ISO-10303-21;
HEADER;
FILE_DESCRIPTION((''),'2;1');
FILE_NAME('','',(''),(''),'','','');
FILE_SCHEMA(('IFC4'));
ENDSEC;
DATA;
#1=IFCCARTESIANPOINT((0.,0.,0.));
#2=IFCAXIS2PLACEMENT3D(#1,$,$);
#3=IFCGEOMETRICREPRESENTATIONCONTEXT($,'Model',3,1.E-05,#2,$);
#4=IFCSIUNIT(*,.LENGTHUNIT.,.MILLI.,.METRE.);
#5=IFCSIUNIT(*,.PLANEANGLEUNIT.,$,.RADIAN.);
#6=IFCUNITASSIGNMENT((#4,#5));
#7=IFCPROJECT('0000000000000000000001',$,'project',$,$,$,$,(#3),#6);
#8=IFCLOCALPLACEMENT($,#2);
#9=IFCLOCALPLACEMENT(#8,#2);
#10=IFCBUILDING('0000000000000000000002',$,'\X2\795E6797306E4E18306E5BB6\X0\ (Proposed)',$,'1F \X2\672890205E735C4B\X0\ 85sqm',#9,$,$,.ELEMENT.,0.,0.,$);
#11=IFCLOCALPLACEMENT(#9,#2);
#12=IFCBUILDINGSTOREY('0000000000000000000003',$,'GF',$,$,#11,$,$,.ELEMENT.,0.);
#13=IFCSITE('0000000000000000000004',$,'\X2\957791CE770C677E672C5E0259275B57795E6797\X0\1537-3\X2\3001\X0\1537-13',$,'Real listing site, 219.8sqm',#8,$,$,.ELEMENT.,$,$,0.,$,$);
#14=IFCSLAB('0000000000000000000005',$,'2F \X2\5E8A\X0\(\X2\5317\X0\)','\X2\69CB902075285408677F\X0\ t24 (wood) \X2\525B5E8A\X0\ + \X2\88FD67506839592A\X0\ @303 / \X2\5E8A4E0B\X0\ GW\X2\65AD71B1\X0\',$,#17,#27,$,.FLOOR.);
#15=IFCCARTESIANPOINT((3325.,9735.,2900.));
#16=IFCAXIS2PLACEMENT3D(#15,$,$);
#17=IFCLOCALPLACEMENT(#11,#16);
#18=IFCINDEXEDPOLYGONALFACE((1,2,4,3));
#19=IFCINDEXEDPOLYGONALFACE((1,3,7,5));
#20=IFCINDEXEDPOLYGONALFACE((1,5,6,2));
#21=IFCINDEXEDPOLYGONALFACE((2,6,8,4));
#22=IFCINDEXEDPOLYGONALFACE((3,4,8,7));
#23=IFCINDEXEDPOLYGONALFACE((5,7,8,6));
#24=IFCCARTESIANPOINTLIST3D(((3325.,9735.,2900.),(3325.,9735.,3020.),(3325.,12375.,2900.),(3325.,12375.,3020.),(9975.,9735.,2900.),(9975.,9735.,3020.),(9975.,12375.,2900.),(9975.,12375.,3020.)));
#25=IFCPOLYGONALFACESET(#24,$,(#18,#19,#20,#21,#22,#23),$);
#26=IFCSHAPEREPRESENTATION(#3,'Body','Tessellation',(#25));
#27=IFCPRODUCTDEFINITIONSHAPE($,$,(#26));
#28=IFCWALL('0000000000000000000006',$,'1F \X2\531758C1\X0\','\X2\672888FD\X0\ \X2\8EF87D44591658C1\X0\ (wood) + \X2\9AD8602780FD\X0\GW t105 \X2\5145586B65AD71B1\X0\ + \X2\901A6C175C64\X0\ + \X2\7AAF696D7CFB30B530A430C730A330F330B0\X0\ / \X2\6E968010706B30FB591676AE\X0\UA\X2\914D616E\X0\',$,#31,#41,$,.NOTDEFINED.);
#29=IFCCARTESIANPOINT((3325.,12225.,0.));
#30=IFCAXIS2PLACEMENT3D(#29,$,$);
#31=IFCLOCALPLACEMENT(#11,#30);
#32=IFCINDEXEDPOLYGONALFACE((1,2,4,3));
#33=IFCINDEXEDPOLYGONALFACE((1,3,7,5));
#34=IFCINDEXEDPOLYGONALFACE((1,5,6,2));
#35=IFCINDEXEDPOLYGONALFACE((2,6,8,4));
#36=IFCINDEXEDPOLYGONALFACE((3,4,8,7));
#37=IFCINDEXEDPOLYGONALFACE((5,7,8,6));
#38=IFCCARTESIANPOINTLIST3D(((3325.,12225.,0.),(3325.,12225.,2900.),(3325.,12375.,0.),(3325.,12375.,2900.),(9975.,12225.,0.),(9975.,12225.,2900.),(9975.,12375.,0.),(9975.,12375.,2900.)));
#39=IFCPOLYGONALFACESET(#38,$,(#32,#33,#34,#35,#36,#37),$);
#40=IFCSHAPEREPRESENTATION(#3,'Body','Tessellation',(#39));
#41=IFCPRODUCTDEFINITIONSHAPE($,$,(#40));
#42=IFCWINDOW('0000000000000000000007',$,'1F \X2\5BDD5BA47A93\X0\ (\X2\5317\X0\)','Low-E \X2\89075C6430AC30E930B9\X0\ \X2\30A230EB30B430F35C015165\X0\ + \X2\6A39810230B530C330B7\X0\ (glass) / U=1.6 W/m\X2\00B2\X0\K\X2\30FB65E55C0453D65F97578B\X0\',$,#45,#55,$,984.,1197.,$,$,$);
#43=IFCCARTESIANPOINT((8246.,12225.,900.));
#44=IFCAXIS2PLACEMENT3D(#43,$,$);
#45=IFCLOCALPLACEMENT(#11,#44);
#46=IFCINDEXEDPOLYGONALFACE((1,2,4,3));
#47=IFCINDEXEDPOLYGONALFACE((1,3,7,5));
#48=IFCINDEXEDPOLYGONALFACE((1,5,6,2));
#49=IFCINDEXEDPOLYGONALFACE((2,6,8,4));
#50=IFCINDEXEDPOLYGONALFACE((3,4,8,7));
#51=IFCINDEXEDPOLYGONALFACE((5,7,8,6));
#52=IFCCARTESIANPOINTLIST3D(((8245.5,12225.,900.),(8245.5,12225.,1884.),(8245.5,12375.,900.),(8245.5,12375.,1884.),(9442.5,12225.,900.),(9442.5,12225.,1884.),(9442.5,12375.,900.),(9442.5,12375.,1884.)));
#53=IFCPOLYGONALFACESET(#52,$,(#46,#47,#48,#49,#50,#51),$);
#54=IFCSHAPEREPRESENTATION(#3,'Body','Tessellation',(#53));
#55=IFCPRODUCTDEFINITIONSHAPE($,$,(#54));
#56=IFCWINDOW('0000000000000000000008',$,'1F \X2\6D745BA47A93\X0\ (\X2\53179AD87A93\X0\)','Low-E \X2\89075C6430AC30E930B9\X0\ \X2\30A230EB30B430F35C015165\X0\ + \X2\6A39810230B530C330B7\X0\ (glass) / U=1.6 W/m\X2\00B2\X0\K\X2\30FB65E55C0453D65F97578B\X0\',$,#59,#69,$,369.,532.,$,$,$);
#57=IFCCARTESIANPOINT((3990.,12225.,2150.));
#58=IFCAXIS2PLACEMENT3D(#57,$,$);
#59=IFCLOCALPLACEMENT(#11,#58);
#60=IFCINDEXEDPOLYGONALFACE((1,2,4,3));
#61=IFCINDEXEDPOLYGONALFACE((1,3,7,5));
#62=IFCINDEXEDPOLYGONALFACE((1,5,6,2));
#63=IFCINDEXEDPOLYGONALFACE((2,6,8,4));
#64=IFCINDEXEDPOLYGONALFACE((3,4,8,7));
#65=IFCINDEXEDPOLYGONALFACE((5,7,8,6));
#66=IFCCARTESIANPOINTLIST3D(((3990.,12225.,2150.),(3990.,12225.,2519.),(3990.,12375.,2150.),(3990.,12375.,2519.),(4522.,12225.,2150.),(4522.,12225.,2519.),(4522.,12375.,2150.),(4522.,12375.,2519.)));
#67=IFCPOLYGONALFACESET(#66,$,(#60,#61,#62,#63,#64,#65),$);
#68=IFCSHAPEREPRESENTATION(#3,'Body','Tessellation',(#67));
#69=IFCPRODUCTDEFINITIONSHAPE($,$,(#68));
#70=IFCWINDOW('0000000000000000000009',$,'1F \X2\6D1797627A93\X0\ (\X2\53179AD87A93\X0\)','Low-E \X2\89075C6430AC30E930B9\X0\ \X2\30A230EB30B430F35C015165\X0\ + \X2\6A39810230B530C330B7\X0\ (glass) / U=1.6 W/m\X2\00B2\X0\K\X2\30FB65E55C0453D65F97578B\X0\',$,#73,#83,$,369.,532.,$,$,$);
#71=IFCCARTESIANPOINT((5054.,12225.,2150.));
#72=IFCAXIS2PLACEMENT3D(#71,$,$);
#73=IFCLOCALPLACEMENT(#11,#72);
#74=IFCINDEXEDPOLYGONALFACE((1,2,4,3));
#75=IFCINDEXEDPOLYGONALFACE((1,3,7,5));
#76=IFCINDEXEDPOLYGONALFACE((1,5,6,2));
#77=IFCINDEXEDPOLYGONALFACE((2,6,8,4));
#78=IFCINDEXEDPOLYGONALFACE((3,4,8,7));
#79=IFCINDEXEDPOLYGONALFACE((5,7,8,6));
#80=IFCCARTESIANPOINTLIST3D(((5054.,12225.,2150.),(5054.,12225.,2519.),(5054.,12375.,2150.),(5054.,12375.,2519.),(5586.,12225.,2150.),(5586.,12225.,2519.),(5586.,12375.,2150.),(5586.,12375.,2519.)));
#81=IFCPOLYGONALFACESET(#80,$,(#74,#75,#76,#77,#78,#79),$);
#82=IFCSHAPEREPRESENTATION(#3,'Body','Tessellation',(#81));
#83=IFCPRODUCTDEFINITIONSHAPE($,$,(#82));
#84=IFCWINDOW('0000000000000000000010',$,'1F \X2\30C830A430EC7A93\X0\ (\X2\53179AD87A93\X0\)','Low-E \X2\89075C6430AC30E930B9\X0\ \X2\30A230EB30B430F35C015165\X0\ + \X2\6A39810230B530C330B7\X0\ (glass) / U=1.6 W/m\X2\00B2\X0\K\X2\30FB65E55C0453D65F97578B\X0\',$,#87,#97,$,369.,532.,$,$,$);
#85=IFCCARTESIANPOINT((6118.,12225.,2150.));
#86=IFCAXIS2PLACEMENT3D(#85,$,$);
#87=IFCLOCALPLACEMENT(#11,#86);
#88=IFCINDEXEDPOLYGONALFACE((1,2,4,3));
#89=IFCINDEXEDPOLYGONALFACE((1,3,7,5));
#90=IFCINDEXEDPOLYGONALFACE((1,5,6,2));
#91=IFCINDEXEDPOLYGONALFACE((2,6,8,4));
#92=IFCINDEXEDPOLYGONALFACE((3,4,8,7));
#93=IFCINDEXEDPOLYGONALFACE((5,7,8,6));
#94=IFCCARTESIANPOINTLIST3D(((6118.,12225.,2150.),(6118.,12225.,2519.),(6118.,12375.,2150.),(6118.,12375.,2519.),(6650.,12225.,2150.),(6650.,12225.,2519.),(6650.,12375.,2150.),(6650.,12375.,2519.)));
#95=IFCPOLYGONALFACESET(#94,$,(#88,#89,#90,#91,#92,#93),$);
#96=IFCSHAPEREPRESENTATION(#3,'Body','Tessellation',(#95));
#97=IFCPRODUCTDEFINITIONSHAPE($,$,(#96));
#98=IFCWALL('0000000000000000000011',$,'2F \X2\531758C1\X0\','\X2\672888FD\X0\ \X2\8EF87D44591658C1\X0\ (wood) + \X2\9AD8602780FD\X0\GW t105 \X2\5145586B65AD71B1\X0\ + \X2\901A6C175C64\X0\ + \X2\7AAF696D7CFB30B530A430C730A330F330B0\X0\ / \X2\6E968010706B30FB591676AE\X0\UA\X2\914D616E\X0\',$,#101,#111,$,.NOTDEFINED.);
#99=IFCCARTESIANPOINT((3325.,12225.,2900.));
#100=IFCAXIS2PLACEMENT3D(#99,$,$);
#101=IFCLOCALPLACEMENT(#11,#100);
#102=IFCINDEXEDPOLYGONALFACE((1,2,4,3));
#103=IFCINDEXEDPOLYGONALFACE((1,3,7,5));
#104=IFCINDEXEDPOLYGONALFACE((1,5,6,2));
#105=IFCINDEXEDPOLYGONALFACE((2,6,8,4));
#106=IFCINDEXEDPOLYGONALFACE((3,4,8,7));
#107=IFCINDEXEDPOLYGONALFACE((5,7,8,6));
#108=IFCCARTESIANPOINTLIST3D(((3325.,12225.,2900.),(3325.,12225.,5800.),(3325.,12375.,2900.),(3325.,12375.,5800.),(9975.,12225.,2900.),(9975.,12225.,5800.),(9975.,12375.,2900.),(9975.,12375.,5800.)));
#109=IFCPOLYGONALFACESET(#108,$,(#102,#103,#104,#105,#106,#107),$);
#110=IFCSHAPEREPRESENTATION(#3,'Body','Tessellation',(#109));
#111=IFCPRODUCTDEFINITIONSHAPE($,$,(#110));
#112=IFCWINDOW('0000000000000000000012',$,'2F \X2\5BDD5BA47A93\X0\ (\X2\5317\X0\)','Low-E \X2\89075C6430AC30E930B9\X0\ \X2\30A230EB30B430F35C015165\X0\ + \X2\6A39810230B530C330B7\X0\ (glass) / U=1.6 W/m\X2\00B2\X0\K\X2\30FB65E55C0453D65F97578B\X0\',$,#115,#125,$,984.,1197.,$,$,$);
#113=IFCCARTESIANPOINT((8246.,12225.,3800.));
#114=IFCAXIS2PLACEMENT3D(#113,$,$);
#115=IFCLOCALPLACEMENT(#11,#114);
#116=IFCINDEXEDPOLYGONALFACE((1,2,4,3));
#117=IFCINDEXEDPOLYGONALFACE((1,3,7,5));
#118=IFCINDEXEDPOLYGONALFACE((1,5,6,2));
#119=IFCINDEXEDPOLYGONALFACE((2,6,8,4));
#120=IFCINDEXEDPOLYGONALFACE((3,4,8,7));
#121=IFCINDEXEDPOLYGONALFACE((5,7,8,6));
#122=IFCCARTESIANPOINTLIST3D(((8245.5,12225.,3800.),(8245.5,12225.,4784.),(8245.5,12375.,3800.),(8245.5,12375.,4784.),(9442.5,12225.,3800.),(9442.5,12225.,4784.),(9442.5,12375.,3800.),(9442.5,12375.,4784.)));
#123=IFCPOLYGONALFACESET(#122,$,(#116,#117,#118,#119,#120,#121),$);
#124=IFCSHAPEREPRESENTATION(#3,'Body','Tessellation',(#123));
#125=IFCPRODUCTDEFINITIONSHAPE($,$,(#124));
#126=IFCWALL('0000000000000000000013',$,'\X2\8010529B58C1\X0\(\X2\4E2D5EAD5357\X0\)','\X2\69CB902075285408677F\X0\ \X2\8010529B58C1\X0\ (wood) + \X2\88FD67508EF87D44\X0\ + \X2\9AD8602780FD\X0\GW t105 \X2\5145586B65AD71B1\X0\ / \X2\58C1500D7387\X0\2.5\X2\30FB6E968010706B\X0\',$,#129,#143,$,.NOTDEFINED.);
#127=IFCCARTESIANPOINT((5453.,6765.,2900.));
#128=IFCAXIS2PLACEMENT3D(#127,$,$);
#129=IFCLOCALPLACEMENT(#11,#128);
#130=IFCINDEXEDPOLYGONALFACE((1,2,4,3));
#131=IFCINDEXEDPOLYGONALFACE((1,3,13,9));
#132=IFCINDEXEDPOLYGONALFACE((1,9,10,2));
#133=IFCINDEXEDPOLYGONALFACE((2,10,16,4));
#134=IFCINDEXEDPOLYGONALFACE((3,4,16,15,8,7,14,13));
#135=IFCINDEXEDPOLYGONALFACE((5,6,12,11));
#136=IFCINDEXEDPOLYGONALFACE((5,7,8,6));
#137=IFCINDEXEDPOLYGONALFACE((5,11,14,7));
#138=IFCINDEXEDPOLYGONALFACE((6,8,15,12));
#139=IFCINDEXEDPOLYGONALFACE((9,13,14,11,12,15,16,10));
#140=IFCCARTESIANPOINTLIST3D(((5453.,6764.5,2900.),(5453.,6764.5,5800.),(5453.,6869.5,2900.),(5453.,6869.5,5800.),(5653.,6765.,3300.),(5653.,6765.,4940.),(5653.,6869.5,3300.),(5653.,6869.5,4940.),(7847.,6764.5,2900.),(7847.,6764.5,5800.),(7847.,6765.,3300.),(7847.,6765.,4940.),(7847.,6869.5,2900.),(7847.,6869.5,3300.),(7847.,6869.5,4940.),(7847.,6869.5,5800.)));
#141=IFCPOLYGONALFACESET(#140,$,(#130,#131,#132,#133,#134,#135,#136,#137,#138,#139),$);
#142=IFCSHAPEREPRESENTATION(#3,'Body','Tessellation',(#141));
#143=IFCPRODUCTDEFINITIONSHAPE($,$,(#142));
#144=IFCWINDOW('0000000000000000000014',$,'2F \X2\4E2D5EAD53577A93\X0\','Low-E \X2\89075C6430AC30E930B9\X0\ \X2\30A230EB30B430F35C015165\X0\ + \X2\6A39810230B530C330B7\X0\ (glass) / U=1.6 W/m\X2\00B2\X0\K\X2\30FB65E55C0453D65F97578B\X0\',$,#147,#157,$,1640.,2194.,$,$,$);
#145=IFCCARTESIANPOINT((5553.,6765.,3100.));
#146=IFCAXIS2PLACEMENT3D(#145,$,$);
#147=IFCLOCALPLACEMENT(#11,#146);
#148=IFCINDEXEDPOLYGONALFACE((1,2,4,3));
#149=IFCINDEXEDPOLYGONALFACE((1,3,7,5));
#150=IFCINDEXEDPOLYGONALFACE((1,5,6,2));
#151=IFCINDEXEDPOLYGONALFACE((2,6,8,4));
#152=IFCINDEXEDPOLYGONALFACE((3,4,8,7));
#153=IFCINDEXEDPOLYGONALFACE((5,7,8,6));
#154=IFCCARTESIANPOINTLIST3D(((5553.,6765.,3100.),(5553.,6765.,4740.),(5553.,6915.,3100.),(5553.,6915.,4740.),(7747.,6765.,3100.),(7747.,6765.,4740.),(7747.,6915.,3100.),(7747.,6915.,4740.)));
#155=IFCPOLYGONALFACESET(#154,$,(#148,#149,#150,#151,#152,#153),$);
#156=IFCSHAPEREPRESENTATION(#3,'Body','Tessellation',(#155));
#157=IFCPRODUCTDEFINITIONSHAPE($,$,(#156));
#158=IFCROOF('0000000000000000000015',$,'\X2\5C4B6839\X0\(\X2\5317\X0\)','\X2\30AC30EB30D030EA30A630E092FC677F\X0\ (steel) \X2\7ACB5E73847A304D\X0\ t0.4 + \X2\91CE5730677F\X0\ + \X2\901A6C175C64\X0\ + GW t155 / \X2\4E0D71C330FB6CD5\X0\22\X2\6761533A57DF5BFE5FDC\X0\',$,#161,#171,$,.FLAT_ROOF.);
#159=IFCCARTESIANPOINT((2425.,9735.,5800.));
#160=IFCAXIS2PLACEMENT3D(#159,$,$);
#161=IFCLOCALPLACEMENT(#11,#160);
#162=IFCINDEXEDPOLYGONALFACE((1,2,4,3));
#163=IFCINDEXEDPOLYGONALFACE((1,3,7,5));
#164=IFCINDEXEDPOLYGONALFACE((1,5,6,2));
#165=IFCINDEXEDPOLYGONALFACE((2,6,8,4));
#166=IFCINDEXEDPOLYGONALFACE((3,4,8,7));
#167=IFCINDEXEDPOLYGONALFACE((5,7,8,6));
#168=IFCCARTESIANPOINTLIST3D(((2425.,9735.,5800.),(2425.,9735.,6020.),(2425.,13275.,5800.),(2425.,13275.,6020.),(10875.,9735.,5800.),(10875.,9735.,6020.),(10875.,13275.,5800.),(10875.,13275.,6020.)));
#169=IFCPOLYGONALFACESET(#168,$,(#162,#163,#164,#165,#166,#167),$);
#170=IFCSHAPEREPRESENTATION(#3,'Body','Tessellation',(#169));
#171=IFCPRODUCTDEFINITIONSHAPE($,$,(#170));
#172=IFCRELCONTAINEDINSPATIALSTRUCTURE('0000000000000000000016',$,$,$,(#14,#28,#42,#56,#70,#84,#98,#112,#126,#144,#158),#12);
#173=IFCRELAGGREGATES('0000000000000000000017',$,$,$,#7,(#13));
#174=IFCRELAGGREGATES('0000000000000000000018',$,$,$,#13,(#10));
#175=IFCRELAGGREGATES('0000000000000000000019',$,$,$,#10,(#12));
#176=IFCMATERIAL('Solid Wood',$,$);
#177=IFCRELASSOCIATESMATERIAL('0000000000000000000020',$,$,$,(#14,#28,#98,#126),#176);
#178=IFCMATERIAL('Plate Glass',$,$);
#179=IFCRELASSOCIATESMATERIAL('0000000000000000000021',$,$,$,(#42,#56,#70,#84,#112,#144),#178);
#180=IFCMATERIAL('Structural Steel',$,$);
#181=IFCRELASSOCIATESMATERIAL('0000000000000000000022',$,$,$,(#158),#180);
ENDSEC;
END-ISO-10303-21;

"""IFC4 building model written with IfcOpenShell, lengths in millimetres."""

from ifc_helpers import new_model, si_unit, frame, frame_2d, origin, place, context, project, spatial, rectangle, extrude, material, element, fill, save


model = new_model("IFC4")

# Units and contexts
model_context = context("Model", 3, precision=1e-05, world=origin())
ifc_project = project(units=[si_unit("LENGTHUNIT", "METRE", prefix="MILLI"), si_unit("PLANEANGLEUNIT", "RADIAN")], contexts=[model_context])

# Site, building, storey
site_placement = place(None, origin())
site = spatial("IfcSite", under=ifc_project, at=site_placement, Name="長野県松本市大字神林1537-3、1537-13", ObjectType="Real listing site, 219.8sqm", CompositionType="ELEMENT", RefElevation=0.0)
building_placement = place(site_placement, origin())
building = spatial("IfcBuilding", under=site, at=building_placement, Name="神林の丘の家 (Proposed)", ObjectType="1F 木造平屋 85sqm", CompositionType="ELEMENT", ElevationOfRefHeight=0.0, ElevationOfTerrain=0.0)
storey_placement = place(building_placement, origin())
storey = spatial("IfcBuildingStorey", under=building, at=storey_placement, Name="GF", CompositionType="ELEMENT", Elevation=0.0)

# Slab
ifc_material_1 = material(Name="Solid Wood")
slab_1_placement = place(storey_placement, frame((3325.0, 9735.0, 2900.0)))
element("IfcSlab", 1, at=slab_1_placement, inside=storey, material=ifc_material_1, Name="2F 床(北)", Description="構造用合板 t24 (wood) 剛床 + 製材根太 @303 / 床下 GW断熱", PredefinedType="FLOOR", context=model_context, shape_type="SweptSolid", body=[
    extrude(rectangle(XDim=6650.0, YDim=2640.0, at=frame_2d((3325.0, 1320.0))), frame((3325.0, 9735.0, 2900.0)), (0.0, 0.0, 1.0), 120.0),
])

# Wall, openings, windows
wall_1_placement = place(storey_placement, frame((3325.0, 12225.0, 0.0)))
wall_1 = element("IfcWall", 2, at=wall_1_placement, inside=storey, material=ifc_material_1, Name="1F 北壁", Description="木製 軸組外壁 (wood) + 高性能GW t105 充填断熱 + 通気層 + 窯業系サイディング / 準耐火・外皮UA配慮", PredefinedType="NOTDEFINED", context=model_context, shape_type="SweptSolid", body=[
    extrude(rectangle(XDim=6650.0, YDim=150.0, at=frame_2d((3325.0, 75.0))), frame((3325.0, 12225.0, 0.0)), (0.0, 0.0, 1.0), 2900.0),
])
opening_1_placement = place(storey_placement, frame((8246.0, 12225.0, 900.0)))
opening_1 = element("IfcOpeningElement", 3, at=opening_1_placement, cuts=wall_1, PredefinedType="NOTDEFINED", context=model_context, shape_type="SweptSolid", body=[
    extrude(rectangle(XDim=1197.0, YDim=150.0, at=frame_2d((598.0, 75.0))), frame((8246.0, 12225.0, 900.0)), (0.0, 0.0, 1.0), 984.0),
])
opening_2_placement = place(storey_placement, frame((3990.0, 12225.0, 2150.0)))
opening_2 = element("IfcOpeningElement", 4, at=opening_2_placement, cuts=wall_1, PredefinedType="NOTDEFINED", context=model_context, shape_type="SweptSolid", body=[
    extrude(rectangle(XDim=532.0, YDim=150.0, at=frame_2d((266.0, 75.0))), frame((3990.0, 12225.0, 2150.0)), (0.0, 0.0, 1.0), 369.0),
])
opening_3_placement = place(storey_placement, frame((5054.0, 12225.0, 2150.0)))
opening_3 = element("IfcOpeningElement", 5, at=opening_3_placement, cuts=wall_1, PredefinedType="NOTDEFINED", context=model_context, shape_type="SweptSolid", body=[
    extrude(rectangle(XDim=532.0, YDim=150.0, at=frame_2d((266.0, 75.0))), frame((5054.0, 12225.0, 2150.0)), (0.0, 0.0, 1.0), 369.0),
])
opening_4_placement = place(storey_placement, frame((6118.0, 12225.0, 2150.0)))
opening_4 = element("IfcOpeningElement", 6, at=opening_4_placement, cuts=wall_1, PredefinedType="NOTDEFINED", context=model_context, shape_type="SweptSolid", body=[
    extrude(rectangle(XDim=532.0, YDim=150.0, at=frame_2d((266.0, 75.0))), frame((6118.0, 12225.0, 2150.0)), (0.0, 0.0, 1.0), 369.0),
])
ifc_material_2 = material(Name="Plate Glass")
window_1_placement = place(storey_placement, frame((8246.0, 12225.0, 900.0)))
window_1 = element("IfcWindow", 7, at=window_1_placement, inside=storey, material=ifc_material_2, Name="1F 寝室窓 (北)", Description="Low-E 複層ガラス アルゴン封入 + 樹脂サッシ (glass) / U=1.6 W/m²K・日射取得型", OverallHeight=984.0, OverallWidth=1197.0, context=model_context, shape_type="SweptSolid", body=[
    extrude(rectangle(XDim=1197.0, YDim=150.0, at=frame_2d((598.0, 75.0))), frame((8246.0, 12225.0, 900.0)), (0.0, 0.0, 1.0), 984.0),
])
fill(opening_1, window_1)
window_2_placement = place(storey_placement, frame((3990.0, 12225.0, 2150.0)))
window_2 = element("IfcWindow", 8, at=window_2_placement, inside=storey, material=ifc_material_2, Name="1F 浴室窓 (北高窓)", Description="Low-E 複層ガラス アルゴン封入 + 樹脂サッシ (glass) / U=1.6 W/m²K・日射取得型", OverallHeight=369.0, OverallWidth=532.0, context=model_context, shape_type="SweptSolid", body=[
    extrude(rectangle(XDim=532.0, YDim=150.0, at=frame_2d((266.0, 75.0))), frame((3990.0, 12225.0, 2150.0)), (0.0, 0.0, 1.0), 369.0),
])
fill(opening_2, window_2)
window_3_placement = place(storey_placement, frame((5054.0, 12225.0, 2150.0)))
window_3 = element("IfcWindow", 9, at=window_3_placement, inside=storey, material=ifc_material_2, Name="1F 洗面窓 (北高窓)", Description="Low-E 複層ガラス アルゴン封入 + 樹脂サッシ (glass) / U=1.6 W/m²K・日射取得型", OverallHeight=369.0, OverallWidth=532.0, context=model_context, shape_type="SweptSolid", body=[
    extrude(rectangle(XDim=532.0, YDim=150.0, at=frame_2d((266.0, 75.0))), frame((5054.0, 12225.0, 2150.0)), (0.0, 0.0, 1.0), 369.0),
])
fill(opening_3, window_3)
window_4_placement = place(storey_placement, frame((6118.0, 12225.0, 2150.0)))
window_4 = element("IfcWindow", 10, at=window_4_placement, inside=storey, material=ifc_material_2, Name="1F トイレ窓 (北高窓)", Description="Low-E 複層ガラス アルゴン封入 + 樹脂サッシ (glass) / U=1.6 W/m²K・日射取得型", OverallHeight=369.0, OverallWidth=532.0, context=model_context, shape_type="SweptSolid", body=[
    extrude(rectangle(XDim=532.0, YDim=150.0, at=frame_2d((266.0, 75.0))), frame((6118.0, 12225.0, 2150.0)), (0.0, 0.0, 1.0), 369.0),
])
fill(opening_4, window_4)

# Walls, openings, windows
wall_2_placement = place(storey_placement, frame((3325.0, 12225.0, 2900.0)))
wall_2 = element("IfcWall", 11, at=wall_2_placement, inside=storey, material=ifc_material_1, Name="2F 北壁", Description="木製 軸組外壁 (wood) + 高性能GW t105 充填断熱 + 通気層 + 窯業系サイディング / 準耐火・外皮UA配慮", PredefinedType="NOTDEFINED", context=model_context, shape_type="SweptSolid", body=[
    extrude(rectangle(XDim=6650.0, YDim=150.0, at=frame_2d((3325.0, 75.0))), frame((3325.0, 12225.0, 2900.0)), (0.0, 0.0, 1.0), 2900.0),
])
opening_5_placement = place(storey_placement, frame((8246.0, 12225.0, 3800.0)))
opening_5 = element("IfcOpeningElement", 12, at=opening_5_placement, cuts=wall_2, PredefinedType="NOTDEFINED", context=model_context, shape_type="SweptSolid", body=[
    extrude(rectangle(XDim=1197.0, YDim=150.0, at=frame_2d((598.0, 75.0))), frame((8246.0, 12225.0, 3800.0)), (0.0, 0.0, 1.0), 984.0),
])
window_5_placement = place(storey_placement, frame((8246.0, 12225.0, 3800.0)))
window_5 = element("IfcWindow", 13, at=window_5_placement, inside=storey, material=ifc_material_2, Name="2F 寝室窓 (北)", Description="Low-E 複層ガラス アルゴン封入 + 樹脂サッシ (glass) / U=1.6 W/m²K・日射取得型", OverallHeight=984.0, OverallWidth=1197.0, context=model_context, shape_type="SweptSolid", body=[
    extrude(rectangle(XDim=1197.0, YDim=150.0, at=frame_2d((598.0, 75.0))), frame((8246.0, 12225.0, 3800.0)), (0.0, 0.0, 1.0), 984.0),
])
fill(opening_5, window_5)
wall_3_placement = place(storey_placement, frame((5453.0, 6765.0, 2900.0)))
wall_3 = element("IfcWall", 14, at=wall_3_placement, inside=storey, material=ifc_material_1, Name="耐力壁(中庭南)", Description="構造用合板 耐力壁 (wood) + 製材軸組 + 高性能GW t105 充填断熱 / 壁倍率2.5・準耐火", PredefinedType="NOTDEFINED", context=model_context, shape_type="SweptSolid", body=[
    extrude(rectangle(XDim=2394.0, YDim=105.0, at=frame_2d((1197.0, 52.0))), frame((5453.0, 6765.0, 2900.0)), (0.0, 0.0, 1.0), 2900.0),
])
opening_6_placement = place(storey_placement, frame((5553.0, 6765.0, 3100.0)))
opening_6 = element("IfcOpeningElement", 15, at=opening_6_placement, cuts=wall_3, PredefinedType="NOTDEFINED", context=model_context, shape_type="SweptSolid", body=[
    extrude(rectangle(XDim=2194.0, YDim=150.0, at=frame_2d((1097.0, 75.0))), frame((5553.0, 6765.0, 3100.0)), (0.0, 0.0, 1.0), 1640.0),
])
window_6_placement = place(storey_placement, frame((5553.0, 6765.0, 3100.0)))
window_6 = element("IfcWindow", 16, at=window_6_placement, inside=storey, material=ifc_material_2, Name="2F 中庭南窓", Description="Low-E 複層ガラス アルゴン封入 + 樹脂サッシ (glass) / U=1.6 W/m²K・日射取得型", OverallHeight=1640.0, OverallWidth=2194.0, context=model_context, shape_type="SweptSolid", body=[
    extrude(rectangle(XDim=2194.0, YDim=150.0, at=frame_2d((1097.0, 75.0))), frame((5553.0, 6765.0, 3100.0)), (0.0, 0.0, 1.0), 1640.0),
])
fill(opening_6, window_6)

# Roof
ifc_material_3 = material(Name="Structural Steel")
for number, where, name in (
    (17, (2425.0, 9735.0, 5800.0), "屋根(北)"),
):
    element("IfcRoof", number, at=place(storey_placement, frame(where)), inside=storey, material=ifc_material_3, Name=name, Description="ガルバリウム鋼板 (steel) 立平葺き t0.4 + 野地板 + 通気層 + GW t155 / 不燃・法22条区域対応", PredefinedType="FLAT_ROOF", context=model_context, shape_type="SweptSolid", body=[
        extrude(rectangle(XDim=8450.0, YDim=3540.0, at=frame_2d((4225.0, 1770.0))), frame((2425.0, 9735.0, 5800.0)), (0.0, 0.0, 1.0), 220.0),
    ])

save(model, "model.ifc")
